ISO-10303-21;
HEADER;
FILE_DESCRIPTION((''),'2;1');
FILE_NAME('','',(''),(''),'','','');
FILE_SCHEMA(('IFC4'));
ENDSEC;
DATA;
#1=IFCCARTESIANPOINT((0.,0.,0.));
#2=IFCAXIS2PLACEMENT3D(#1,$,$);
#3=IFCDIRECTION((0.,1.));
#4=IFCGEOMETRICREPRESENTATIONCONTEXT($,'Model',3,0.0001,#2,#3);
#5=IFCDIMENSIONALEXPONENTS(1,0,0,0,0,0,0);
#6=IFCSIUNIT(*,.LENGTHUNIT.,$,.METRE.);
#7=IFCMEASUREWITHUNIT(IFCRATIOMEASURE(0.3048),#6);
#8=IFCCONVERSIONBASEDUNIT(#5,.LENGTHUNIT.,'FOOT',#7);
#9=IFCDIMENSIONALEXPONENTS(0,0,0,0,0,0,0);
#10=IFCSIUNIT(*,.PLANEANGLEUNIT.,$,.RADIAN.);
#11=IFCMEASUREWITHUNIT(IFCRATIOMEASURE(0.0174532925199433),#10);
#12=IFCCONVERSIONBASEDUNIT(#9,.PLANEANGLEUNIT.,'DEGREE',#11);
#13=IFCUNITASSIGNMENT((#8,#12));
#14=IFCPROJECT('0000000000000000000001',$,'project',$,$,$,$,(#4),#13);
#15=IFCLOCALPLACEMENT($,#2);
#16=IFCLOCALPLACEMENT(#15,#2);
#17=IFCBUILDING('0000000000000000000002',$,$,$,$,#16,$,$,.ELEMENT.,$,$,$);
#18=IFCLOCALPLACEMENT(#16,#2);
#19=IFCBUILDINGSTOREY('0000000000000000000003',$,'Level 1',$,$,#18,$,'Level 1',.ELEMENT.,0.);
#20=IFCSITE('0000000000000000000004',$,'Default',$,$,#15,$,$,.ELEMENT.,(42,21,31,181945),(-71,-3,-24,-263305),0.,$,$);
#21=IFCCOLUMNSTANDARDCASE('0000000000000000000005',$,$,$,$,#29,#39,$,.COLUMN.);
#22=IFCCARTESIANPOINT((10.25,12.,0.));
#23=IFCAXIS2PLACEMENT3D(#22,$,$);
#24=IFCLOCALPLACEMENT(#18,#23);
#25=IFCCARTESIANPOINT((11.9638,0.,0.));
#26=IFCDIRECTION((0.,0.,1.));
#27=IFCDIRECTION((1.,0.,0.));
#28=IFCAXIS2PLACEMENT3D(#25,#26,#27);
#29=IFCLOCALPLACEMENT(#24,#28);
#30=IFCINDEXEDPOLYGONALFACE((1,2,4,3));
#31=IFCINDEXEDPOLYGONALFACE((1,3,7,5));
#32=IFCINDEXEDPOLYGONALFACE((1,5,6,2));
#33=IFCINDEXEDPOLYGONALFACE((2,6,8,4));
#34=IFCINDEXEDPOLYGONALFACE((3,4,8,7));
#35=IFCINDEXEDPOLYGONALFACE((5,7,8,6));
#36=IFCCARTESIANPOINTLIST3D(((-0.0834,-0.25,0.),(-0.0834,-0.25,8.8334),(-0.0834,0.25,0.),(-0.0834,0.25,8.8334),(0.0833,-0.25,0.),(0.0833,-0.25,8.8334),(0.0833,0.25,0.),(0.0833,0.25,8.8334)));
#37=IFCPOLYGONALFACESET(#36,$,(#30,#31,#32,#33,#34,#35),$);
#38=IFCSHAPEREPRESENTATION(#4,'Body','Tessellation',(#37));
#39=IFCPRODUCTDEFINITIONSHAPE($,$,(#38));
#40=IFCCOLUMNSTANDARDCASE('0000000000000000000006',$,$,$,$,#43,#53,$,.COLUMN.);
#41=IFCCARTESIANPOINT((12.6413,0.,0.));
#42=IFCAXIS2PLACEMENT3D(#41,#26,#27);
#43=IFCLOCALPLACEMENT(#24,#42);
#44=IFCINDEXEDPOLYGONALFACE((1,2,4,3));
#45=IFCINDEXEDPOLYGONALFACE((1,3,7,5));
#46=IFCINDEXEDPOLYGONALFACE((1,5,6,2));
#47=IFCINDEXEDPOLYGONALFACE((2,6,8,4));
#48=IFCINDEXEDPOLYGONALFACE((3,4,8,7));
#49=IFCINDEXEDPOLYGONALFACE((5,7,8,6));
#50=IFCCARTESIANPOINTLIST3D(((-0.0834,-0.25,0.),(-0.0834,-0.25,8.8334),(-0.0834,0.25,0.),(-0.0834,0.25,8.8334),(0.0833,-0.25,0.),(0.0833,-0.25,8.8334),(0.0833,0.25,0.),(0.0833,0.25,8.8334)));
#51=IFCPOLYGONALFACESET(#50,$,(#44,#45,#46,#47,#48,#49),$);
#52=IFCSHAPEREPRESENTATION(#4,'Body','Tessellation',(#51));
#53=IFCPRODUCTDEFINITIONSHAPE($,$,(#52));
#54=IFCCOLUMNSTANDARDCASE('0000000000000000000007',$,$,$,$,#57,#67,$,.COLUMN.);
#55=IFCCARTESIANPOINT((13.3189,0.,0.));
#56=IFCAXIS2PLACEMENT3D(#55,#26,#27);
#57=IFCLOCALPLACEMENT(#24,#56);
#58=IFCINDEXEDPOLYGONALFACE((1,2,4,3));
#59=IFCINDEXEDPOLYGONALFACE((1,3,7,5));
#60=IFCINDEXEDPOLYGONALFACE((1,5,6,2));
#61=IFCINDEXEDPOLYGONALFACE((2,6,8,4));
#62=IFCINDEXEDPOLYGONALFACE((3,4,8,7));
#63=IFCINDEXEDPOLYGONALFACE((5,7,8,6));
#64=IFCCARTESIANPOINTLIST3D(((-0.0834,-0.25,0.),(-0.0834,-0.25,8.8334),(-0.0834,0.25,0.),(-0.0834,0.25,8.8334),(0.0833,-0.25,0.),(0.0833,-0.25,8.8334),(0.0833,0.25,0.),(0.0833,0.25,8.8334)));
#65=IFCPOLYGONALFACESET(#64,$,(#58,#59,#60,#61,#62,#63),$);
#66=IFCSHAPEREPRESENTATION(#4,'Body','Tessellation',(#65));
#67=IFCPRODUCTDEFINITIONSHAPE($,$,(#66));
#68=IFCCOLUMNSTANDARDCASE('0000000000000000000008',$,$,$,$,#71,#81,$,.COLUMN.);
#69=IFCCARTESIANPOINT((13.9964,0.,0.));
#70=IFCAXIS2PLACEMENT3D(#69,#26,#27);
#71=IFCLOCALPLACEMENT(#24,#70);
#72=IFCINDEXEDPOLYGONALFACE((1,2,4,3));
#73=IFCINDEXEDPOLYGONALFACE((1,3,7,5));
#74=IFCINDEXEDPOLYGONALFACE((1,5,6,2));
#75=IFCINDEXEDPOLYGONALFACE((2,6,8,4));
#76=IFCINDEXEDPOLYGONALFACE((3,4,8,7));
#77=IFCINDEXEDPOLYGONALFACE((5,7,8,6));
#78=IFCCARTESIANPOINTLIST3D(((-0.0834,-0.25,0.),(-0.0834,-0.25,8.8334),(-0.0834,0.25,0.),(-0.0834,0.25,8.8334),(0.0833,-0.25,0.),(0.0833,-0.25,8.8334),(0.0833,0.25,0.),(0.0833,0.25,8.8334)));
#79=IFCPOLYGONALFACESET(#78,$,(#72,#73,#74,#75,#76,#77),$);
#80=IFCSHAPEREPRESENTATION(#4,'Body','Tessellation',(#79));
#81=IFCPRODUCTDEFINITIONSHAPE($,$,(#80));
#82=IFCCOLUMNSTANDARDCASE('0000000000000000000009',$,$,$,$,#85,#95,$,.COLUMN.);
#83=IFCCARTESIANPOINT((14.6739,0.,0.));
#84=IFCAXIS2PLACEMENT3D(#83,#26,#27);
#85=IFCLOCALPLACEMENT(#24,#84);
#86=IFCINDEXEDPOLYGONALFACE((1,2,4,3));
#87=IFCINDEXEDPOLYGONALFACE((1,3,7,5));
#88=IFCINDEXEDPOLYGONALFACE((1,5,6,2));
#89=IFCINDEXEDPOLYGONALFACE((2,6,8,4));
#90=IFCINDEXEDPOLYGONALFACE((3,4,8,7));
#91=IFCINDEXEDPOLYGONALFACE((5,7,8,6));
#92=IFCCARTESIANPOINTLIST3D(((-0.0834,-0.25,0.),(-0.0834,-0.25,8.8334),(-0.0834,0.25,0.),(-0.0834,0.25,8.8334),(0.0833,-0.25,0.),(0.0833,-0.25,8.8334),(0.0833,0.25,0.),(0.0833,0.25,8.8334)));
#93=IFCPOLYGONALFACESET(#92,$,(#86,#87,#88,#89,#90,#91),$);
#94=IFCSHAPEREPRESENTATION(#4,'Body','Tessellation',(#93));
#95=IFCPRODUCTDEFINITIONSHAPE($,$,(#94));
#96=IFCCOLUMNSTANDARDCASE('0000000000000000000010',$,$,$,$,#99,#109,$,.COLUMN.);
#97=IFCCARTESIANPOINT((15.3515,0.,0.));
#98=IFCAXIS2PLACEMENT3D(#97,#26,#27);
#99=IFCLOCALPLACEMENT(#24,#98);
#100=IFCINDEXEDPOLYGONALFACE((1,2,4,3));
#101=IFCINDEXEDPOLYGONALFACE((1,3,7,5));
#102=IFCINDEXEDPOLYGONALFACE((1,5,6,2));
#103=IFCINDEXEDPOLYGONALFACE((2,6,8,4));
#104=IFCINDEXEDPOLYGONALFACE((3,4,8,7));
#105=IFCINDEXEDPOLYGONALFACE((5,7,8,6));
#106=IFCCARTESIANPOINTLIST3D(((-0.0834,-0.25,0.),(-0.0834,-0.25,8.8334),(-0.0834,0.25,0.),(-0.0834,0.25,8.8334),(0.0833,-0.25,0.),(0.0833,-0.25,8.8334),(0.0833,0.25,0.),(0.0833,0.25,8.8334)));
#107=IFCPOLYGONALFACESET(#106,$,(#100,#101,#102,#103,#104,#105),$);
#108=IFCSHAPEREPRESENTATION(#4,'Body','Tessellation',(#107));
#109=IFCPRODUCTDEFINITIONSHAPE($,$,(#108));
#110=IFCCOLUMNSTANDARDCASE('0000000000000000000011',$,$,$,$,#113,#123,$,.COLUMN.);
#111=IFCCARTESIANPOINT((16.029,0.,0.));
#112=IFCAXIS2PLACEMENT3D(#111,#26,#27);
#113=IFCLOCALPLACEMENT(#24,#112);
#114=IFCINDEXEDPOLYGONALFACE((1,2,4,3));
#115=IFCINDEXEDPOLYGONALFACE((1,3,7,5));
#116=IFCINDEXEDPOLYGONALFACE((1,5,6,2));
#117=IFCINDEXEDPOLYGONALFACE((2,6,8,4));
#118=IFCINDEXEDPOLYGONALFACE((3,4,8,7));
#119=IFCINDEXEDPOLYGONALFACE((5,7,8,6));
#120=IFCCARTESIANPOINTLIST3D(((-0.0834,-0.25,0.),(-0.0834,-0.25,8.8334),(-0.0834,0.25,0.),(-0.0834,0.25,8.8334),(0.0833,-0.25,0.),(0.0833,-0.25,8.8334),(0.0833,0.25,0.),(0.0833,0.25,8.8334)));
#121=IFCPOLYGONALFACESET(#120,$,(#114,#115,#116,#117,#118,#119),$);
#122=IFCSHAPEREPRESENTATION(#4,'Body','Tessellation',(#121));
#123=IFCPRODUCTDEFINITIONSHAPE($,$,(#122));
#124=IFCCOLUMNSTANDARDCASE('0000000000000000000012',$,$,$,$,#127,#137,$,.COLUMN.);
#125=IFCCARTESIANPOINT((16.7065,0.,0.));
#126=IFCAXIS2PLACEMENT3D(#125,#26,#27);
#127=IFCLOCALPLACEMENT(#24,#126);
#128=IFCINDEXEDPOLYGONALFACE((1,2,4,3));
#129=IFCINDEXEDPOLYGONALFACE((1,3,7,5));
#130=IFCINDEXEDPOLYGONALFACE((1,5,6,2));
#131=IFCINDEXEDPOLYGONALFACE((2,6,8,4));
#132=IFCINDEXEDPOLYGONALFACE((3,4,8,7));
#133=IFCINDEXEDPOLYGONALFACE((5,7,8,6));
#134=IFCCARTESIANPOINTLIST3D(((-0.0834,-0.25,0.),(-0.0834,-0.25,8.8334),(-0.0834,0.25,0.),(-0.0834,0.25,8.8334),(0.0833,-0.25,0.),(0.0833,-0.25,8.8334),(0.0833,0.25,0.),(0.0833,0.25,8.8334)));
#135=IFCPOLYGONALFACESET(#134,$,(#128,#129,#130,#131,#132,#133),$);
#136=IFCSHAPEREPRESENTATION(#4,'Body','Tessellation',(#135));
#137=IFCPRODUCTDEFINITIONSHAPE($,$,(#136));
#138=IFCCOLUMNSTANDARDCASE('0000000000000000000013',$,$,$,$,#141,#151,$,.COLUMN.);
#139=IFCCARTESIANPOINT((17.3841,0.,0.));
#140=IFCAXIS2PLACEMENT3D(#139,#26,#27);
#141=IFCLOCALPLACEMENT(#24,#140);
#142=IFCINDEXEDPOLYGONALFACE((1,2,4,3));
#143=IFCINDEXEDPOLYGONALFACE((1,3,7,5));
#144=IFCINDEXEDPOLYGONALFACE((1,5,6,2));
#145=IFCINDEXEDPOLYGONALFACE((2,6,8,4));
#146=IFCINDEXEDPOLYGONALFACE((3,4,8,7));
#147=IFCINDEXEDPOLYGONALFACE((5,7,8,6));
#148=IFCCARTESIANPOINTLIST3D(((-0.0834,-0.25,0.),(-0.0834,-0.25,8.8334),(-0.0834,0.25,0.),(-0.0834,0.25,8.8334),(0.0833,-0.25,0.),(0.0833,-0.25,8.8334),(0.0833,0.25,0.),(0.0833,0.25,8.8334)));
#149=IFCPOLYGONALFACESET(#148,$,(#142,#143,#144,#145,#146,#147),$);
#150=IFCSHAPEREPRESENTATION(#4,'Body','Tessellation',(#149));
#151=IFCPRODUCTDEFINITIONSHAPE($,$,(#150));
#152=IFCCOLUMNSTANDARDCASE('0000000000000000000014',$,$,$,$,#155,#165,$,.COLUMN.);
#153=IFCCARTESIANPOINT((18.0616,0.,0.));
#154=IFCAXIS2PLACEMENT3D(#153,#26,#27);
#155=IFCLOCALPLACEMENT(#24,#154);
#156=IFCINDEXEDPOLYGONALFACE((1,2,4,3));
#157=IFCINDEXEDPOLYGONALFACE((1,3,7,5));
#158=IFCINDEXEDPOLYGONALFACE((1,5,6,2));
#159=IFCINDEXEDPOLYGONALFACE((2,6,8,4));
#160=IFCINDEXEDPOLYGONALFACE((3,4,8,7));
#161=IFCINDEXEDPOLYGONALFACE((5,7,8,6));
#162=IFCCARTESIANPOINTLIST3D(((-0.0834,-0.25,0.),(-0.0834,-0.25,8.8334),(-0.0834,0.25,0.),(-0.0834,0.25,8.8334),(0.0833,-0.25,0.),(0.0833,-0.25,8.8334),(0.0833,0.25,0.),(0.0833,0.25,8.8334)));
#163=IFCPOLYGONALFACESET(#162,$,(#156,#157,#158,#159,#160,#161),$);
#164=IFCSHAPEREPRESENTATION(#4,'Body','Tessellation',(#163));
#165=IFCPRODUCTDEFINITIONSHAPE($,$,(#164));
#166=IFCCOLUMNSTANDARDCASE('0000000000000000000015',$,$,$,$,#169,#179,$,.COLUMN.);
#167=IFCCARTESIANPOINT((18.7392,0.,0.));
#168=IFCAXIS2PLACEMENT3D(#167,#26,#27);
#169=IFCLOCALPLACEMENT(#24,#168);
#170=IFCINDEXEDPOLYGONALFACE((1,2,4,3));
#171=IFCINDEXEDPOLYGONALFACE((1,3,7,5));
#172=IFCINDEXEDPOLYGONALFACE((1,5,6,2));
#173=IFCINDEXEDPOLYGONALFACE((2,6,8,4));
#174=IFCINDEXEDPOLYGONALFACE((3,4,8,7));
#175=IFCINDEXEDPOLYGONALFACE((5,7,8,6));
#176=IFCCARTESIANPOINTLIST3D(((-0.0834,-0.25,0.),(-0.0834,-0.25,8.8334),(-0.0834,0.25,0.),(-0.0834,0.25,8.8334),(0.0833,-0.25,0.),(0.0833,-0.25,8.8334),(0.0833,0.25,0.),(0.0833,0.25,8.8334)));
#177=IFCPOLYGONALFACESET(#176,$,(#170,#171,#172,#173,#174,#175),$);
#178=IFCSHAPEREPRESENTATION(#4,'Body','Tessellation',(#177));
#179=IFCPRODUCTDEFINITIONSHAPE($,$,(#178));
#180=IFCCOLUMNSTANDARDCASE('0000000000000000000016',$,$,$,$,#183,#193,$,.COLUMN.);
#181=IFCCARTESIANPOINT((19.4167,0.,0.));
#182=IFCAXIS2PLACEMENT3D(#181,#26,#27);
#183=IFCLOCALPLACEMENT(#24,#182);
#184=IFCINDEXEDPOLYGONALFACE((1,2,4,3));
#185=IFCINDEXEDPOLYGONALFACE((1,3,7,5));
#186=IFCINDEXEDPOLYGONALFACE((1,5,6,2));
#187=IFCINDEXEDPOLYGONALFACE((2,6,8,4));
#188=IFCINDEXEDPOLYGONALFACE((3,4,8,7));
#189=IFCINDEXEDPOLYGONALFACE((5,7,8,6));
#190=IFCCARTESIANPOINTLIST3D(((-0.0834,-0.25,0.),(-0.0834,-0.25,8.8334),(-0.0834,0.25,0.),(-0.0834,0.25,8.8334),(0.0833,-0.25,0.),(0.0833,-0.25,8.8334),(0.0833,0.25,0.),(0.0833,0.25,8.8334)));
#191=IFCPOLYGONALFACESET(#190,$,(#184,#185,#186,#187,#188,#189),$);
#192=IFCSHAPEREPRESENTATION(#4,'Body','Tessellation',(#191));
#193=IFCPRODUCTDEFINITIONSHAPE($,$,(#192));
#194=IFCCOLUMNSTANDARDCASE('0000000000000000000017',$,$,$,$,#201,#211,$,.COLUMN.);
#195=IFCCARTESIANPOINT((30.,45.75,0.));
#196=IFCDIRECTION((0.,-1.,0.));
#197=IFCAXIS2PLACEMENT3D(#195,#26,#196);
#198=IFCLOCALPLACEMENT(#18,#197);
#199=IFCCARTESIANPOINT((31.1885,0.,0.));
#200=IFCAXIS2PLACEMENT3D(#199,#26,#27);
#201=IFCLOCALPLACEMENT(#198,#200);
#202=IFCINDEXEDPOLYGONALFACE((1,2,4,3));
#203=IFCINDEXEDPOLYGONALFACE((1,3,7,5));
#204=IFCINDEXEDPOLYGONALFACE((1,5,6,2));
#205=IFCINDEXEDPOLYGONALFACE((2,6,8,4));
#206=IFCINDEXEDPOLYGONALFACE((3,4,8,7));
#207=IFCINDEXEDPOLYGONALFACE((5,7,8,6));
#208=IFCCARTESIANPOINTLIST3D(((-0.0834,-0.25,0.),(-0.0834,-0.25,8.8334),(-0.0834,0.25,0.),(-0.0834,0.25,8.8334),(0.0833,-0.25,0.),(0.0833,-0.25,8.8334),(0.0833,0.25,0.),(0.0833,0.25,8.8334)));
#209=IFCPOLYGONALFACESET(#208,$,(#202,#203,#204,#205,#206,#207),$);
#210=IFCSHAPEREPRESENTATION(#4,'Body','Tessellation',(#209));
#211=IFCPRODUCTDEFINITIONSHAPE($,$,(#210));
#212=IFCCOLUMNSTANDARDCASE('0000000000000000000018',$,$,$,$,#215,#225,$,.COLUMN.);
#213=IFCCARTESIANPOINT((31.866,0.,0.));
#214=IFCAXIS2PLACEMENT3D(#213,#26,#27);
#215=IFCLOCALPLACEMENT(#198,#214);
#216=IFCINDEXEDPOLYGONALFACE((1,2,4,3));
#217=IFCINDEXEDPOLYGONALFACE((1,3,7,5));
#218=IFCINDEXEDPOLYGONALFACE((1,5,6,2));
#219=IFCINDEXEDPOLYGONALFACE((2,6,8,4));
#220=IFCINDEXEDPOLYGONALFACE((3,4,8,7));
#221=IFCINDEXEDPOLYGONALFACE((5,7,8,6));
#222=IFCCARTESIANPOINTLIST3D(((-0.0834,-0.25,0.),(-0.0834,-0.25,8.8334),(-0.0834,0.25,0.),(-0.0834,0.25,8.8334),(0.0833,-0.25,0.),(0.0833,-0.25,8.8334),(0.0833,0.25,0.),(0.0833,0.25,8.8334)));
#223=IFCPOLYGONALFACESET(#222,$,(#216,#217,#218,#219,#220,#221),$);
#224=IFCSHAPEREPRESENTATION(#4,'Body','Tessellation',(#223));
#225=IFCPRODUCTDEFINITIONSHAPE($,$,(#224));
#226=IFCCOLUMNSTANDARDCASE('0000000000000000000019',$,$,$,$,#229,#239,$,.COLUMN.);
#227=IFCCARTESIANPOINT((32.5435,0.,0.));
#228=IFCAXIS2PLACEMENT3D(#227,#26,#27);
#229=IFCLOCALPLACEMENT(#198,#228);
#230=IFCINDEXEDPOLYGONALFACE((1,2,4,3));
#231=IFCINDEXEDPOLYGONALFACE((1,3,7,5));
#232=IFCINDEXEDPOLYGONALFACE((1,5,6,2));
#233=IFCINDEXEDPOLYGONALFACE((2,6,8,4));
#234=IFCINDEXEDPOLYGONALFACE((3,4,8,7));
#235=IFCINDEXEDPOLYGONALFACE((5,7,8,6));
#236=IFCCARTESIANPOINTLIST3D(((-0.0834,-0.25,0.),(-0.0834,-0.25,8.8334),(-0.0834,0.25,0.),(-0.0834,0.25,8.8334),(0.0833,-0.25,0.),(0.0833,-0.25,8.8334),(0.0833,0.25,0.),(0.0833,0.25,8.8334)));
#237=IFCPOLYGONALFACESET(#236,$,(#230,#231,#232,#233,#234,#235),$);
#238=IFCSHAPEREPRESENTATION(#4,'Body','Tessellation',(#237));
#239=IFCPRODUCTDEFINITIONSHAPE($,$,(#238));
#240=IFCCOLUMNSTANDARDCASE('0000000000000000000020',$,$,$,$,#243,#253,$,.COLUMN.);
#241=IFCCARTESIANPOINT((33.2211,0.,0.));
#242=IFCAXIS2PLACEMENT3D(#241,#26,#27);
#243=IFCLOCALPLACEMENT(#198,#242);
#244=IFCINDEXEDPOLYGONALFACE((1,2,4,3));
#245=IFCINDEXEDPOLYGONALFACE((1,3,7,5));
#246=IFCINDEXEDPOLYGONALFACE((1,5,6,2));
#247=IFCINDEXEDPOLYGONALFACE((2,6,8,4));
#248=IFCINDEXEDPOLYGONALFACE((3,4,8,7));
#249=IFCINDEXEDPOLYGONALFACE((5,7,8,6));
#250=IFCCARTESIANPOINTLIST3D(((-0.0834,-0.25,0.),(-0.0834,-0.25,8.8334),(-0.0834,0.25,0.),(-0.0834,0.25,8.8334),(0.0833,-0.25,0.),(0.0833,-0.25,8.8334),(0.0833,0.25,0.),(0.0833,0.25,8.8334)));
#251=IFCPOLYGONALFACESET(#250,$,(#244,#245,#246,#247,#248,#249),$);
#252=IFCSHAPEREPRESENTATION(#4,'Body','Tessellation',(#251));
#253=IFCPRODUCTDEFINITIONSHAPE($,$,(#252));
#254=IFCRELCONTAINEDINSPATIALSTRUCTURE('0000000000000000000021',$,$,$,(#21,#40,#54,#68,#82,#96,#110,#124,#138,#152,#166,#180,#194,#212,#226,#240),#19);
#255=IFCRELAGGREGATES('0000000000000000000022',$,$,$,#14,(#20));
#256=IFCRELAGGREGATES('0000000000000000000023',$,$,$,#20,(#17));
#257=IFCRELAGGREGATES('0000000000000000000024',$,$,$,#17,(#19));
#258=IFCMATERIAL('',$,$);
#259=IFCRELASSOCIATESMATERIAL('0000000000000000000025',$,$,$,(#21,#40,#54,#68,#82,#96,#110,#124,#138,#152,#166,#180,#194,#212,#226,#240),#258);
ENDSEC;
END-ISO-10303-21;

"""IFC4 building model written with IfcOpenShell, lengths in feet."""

from ifc_helpers import new_model, entity, si_unit, converted_unit, direction, frame, origin, place, context, project, spatial, rectangle, extrude, material, element, save


model = new_model("IFC4")

# Units and contexts
model_context = context("Model", 3, precision=0.0001, world=origin(), true_north=direction((0.0, 1.0)))
ifc_project = project(units=[converted_unit("LENGTHUNIT", "FOOT", entity("IfcRatioMeasure", 0.3048), si_unit("LENGTHUNIT", "METRE"), dimensions=[1, 0, 0, 0, 0, 0, 0]), converted_unit("PLANEANGLEUNIT", "DEGREE", entity("IfcRatioMeasure", 0.0174532925199433), si_unit("PLANEANGLEUNIT", "RADIAN"), dimensions=[0, 0, 0, 0, 0, 0, 0])], contexts=[model_context])

# Site, building, storey
site_placement = place(None, origin())
site = spatial("IfcSite", under=ifc_project, at=site_placement, Name="Default", CompositionType="ELEMENT", RefLatitude=(42, 21, 31, 181945), RefLongitude=(-71, -3, -24, -263305), RefElevation=0.0)
building_placement = place(site_placement, origin())
building = spatial("IfcBuilding", under=site, at=building_placement, CompositionType="ELEMENT")
storey_placement = place(building_placement, origin())
storey = spatial("IfcBuildingStorey", under=building, at=storey_placement, Name="Level 1", LongName="Level 1", CompositionType="ELEMENT", Elevation=0.0)

# Columns
ifc_material_1 = material(Name="")
placement_1 = place(storey_placement, frame((10.25, 12.0, 0.0)))
for number, where, z_axis, x_axis in (
    (1, (11.9638, 0.0, 0.0), (0.0, 0.0, 1.0), (1.0, 0.0, 0.0)),
    (2, (12.6413, 0.0, 0.0), (0.0, 0.0, 1.0), (1.0, 0.0, 0.0)),
    (3, (13.3189, 0.0, 0.0), (0.0, 0.0, 1.0), (1.0, 0.0, 0.0)),
    (4, (13.9964, 0.0, 0.0), (0.0, 0.0, 1.0), (1.0, 0.0, 0.0)),
    (5, (14.6739, 0.0, 0.0), (0.0, 0.0, 1.0), (1.0, 0.0, 0.0)),
    (6, (15.3515, 0.0, 0.0), (0.0, 0.0, 1.0), (1.0, 0.0, 0.0)),
    (7, (16.029, 0.0, 0.0), (0.0, 0.0, 1.0), (1.0, 0.0, 0.0)),
    (8, (16.7065, 0.0, 0.0), (0.0, 0.0, 1.0), (1.0, 0.0, 0.0)),
    (9, (17.3841, 0.0, 0.0), (0.0, 0.0, 1.0), (1.0, 0.0, 0.0)),
    (10, (18.0616, 0.0, 0.0), (0.0, 0.0, 1.0), (1.0, 0.0, 0.0)),
    (11, (18.7392, 0.0, 0.0), (0.0, 0.0, 1.0), (1.0, 0.0, 0.0)),
    (12, (19.4167, 0.0, 0.0), (0.0, 0.0, 1.0), (1.0, 0.0, 0.0)),
):
    element("IfcColumnStandardCase", number, at=place(placement_1, frame(where, z_axis=z_axis, x_axis=x_axis)), inside=storey, material=ifc_material_1, PredefinedType="COLUMN", context=model_context, shape_type="SweptSolid", body=[
        extrude(rectangle(XDim=0.1667, YDim=0.5), origin(), (0.0, 0.0, 1.0), 8.8334),
    ])
placement_2 = place(storey_placement, frame((30.0, 45.75, 0.0), z_axis=(0.0, 0.0, 1.0), x_axis=(0.0, -1.0, 0.0)))
for number, where, z_axis, x_axis in (
    (13, (31.1885, 0.0, 0.0), (0.0, 0.0, 1.0), (1.0, 0.0, 0.0)),
    (14, (31.866, 0.0, 0.0), (0.0, 0.0, 1.0), (1.0, 0.0, 0.0)),
    (15, (32.5435, 0.0, 0.0), (0.0, 0.0, 1.0), (1.0, 0.0, 0.0)),
    (16, (33.2211, 0.0, 0.0), (0.0, 0.0, 1.0), (1.0, 0.0, 0.0)),
):
    element("IfcColumnStandardCase", number, at=place(placement_2, frame(where, z_axis=z_axis, x_axis=x_axis)), inside=storey, material=ifc_material_1, PredefinedType="COLUMN", context=model_context, shape_type="SweptSolid", body=[
        extrude(rectangle(XDim=0.1667, YDim=0.5), origin(), (0.0, 0.0, 1.0), 8.8334),
    ])

save(model, "model.ifc")
